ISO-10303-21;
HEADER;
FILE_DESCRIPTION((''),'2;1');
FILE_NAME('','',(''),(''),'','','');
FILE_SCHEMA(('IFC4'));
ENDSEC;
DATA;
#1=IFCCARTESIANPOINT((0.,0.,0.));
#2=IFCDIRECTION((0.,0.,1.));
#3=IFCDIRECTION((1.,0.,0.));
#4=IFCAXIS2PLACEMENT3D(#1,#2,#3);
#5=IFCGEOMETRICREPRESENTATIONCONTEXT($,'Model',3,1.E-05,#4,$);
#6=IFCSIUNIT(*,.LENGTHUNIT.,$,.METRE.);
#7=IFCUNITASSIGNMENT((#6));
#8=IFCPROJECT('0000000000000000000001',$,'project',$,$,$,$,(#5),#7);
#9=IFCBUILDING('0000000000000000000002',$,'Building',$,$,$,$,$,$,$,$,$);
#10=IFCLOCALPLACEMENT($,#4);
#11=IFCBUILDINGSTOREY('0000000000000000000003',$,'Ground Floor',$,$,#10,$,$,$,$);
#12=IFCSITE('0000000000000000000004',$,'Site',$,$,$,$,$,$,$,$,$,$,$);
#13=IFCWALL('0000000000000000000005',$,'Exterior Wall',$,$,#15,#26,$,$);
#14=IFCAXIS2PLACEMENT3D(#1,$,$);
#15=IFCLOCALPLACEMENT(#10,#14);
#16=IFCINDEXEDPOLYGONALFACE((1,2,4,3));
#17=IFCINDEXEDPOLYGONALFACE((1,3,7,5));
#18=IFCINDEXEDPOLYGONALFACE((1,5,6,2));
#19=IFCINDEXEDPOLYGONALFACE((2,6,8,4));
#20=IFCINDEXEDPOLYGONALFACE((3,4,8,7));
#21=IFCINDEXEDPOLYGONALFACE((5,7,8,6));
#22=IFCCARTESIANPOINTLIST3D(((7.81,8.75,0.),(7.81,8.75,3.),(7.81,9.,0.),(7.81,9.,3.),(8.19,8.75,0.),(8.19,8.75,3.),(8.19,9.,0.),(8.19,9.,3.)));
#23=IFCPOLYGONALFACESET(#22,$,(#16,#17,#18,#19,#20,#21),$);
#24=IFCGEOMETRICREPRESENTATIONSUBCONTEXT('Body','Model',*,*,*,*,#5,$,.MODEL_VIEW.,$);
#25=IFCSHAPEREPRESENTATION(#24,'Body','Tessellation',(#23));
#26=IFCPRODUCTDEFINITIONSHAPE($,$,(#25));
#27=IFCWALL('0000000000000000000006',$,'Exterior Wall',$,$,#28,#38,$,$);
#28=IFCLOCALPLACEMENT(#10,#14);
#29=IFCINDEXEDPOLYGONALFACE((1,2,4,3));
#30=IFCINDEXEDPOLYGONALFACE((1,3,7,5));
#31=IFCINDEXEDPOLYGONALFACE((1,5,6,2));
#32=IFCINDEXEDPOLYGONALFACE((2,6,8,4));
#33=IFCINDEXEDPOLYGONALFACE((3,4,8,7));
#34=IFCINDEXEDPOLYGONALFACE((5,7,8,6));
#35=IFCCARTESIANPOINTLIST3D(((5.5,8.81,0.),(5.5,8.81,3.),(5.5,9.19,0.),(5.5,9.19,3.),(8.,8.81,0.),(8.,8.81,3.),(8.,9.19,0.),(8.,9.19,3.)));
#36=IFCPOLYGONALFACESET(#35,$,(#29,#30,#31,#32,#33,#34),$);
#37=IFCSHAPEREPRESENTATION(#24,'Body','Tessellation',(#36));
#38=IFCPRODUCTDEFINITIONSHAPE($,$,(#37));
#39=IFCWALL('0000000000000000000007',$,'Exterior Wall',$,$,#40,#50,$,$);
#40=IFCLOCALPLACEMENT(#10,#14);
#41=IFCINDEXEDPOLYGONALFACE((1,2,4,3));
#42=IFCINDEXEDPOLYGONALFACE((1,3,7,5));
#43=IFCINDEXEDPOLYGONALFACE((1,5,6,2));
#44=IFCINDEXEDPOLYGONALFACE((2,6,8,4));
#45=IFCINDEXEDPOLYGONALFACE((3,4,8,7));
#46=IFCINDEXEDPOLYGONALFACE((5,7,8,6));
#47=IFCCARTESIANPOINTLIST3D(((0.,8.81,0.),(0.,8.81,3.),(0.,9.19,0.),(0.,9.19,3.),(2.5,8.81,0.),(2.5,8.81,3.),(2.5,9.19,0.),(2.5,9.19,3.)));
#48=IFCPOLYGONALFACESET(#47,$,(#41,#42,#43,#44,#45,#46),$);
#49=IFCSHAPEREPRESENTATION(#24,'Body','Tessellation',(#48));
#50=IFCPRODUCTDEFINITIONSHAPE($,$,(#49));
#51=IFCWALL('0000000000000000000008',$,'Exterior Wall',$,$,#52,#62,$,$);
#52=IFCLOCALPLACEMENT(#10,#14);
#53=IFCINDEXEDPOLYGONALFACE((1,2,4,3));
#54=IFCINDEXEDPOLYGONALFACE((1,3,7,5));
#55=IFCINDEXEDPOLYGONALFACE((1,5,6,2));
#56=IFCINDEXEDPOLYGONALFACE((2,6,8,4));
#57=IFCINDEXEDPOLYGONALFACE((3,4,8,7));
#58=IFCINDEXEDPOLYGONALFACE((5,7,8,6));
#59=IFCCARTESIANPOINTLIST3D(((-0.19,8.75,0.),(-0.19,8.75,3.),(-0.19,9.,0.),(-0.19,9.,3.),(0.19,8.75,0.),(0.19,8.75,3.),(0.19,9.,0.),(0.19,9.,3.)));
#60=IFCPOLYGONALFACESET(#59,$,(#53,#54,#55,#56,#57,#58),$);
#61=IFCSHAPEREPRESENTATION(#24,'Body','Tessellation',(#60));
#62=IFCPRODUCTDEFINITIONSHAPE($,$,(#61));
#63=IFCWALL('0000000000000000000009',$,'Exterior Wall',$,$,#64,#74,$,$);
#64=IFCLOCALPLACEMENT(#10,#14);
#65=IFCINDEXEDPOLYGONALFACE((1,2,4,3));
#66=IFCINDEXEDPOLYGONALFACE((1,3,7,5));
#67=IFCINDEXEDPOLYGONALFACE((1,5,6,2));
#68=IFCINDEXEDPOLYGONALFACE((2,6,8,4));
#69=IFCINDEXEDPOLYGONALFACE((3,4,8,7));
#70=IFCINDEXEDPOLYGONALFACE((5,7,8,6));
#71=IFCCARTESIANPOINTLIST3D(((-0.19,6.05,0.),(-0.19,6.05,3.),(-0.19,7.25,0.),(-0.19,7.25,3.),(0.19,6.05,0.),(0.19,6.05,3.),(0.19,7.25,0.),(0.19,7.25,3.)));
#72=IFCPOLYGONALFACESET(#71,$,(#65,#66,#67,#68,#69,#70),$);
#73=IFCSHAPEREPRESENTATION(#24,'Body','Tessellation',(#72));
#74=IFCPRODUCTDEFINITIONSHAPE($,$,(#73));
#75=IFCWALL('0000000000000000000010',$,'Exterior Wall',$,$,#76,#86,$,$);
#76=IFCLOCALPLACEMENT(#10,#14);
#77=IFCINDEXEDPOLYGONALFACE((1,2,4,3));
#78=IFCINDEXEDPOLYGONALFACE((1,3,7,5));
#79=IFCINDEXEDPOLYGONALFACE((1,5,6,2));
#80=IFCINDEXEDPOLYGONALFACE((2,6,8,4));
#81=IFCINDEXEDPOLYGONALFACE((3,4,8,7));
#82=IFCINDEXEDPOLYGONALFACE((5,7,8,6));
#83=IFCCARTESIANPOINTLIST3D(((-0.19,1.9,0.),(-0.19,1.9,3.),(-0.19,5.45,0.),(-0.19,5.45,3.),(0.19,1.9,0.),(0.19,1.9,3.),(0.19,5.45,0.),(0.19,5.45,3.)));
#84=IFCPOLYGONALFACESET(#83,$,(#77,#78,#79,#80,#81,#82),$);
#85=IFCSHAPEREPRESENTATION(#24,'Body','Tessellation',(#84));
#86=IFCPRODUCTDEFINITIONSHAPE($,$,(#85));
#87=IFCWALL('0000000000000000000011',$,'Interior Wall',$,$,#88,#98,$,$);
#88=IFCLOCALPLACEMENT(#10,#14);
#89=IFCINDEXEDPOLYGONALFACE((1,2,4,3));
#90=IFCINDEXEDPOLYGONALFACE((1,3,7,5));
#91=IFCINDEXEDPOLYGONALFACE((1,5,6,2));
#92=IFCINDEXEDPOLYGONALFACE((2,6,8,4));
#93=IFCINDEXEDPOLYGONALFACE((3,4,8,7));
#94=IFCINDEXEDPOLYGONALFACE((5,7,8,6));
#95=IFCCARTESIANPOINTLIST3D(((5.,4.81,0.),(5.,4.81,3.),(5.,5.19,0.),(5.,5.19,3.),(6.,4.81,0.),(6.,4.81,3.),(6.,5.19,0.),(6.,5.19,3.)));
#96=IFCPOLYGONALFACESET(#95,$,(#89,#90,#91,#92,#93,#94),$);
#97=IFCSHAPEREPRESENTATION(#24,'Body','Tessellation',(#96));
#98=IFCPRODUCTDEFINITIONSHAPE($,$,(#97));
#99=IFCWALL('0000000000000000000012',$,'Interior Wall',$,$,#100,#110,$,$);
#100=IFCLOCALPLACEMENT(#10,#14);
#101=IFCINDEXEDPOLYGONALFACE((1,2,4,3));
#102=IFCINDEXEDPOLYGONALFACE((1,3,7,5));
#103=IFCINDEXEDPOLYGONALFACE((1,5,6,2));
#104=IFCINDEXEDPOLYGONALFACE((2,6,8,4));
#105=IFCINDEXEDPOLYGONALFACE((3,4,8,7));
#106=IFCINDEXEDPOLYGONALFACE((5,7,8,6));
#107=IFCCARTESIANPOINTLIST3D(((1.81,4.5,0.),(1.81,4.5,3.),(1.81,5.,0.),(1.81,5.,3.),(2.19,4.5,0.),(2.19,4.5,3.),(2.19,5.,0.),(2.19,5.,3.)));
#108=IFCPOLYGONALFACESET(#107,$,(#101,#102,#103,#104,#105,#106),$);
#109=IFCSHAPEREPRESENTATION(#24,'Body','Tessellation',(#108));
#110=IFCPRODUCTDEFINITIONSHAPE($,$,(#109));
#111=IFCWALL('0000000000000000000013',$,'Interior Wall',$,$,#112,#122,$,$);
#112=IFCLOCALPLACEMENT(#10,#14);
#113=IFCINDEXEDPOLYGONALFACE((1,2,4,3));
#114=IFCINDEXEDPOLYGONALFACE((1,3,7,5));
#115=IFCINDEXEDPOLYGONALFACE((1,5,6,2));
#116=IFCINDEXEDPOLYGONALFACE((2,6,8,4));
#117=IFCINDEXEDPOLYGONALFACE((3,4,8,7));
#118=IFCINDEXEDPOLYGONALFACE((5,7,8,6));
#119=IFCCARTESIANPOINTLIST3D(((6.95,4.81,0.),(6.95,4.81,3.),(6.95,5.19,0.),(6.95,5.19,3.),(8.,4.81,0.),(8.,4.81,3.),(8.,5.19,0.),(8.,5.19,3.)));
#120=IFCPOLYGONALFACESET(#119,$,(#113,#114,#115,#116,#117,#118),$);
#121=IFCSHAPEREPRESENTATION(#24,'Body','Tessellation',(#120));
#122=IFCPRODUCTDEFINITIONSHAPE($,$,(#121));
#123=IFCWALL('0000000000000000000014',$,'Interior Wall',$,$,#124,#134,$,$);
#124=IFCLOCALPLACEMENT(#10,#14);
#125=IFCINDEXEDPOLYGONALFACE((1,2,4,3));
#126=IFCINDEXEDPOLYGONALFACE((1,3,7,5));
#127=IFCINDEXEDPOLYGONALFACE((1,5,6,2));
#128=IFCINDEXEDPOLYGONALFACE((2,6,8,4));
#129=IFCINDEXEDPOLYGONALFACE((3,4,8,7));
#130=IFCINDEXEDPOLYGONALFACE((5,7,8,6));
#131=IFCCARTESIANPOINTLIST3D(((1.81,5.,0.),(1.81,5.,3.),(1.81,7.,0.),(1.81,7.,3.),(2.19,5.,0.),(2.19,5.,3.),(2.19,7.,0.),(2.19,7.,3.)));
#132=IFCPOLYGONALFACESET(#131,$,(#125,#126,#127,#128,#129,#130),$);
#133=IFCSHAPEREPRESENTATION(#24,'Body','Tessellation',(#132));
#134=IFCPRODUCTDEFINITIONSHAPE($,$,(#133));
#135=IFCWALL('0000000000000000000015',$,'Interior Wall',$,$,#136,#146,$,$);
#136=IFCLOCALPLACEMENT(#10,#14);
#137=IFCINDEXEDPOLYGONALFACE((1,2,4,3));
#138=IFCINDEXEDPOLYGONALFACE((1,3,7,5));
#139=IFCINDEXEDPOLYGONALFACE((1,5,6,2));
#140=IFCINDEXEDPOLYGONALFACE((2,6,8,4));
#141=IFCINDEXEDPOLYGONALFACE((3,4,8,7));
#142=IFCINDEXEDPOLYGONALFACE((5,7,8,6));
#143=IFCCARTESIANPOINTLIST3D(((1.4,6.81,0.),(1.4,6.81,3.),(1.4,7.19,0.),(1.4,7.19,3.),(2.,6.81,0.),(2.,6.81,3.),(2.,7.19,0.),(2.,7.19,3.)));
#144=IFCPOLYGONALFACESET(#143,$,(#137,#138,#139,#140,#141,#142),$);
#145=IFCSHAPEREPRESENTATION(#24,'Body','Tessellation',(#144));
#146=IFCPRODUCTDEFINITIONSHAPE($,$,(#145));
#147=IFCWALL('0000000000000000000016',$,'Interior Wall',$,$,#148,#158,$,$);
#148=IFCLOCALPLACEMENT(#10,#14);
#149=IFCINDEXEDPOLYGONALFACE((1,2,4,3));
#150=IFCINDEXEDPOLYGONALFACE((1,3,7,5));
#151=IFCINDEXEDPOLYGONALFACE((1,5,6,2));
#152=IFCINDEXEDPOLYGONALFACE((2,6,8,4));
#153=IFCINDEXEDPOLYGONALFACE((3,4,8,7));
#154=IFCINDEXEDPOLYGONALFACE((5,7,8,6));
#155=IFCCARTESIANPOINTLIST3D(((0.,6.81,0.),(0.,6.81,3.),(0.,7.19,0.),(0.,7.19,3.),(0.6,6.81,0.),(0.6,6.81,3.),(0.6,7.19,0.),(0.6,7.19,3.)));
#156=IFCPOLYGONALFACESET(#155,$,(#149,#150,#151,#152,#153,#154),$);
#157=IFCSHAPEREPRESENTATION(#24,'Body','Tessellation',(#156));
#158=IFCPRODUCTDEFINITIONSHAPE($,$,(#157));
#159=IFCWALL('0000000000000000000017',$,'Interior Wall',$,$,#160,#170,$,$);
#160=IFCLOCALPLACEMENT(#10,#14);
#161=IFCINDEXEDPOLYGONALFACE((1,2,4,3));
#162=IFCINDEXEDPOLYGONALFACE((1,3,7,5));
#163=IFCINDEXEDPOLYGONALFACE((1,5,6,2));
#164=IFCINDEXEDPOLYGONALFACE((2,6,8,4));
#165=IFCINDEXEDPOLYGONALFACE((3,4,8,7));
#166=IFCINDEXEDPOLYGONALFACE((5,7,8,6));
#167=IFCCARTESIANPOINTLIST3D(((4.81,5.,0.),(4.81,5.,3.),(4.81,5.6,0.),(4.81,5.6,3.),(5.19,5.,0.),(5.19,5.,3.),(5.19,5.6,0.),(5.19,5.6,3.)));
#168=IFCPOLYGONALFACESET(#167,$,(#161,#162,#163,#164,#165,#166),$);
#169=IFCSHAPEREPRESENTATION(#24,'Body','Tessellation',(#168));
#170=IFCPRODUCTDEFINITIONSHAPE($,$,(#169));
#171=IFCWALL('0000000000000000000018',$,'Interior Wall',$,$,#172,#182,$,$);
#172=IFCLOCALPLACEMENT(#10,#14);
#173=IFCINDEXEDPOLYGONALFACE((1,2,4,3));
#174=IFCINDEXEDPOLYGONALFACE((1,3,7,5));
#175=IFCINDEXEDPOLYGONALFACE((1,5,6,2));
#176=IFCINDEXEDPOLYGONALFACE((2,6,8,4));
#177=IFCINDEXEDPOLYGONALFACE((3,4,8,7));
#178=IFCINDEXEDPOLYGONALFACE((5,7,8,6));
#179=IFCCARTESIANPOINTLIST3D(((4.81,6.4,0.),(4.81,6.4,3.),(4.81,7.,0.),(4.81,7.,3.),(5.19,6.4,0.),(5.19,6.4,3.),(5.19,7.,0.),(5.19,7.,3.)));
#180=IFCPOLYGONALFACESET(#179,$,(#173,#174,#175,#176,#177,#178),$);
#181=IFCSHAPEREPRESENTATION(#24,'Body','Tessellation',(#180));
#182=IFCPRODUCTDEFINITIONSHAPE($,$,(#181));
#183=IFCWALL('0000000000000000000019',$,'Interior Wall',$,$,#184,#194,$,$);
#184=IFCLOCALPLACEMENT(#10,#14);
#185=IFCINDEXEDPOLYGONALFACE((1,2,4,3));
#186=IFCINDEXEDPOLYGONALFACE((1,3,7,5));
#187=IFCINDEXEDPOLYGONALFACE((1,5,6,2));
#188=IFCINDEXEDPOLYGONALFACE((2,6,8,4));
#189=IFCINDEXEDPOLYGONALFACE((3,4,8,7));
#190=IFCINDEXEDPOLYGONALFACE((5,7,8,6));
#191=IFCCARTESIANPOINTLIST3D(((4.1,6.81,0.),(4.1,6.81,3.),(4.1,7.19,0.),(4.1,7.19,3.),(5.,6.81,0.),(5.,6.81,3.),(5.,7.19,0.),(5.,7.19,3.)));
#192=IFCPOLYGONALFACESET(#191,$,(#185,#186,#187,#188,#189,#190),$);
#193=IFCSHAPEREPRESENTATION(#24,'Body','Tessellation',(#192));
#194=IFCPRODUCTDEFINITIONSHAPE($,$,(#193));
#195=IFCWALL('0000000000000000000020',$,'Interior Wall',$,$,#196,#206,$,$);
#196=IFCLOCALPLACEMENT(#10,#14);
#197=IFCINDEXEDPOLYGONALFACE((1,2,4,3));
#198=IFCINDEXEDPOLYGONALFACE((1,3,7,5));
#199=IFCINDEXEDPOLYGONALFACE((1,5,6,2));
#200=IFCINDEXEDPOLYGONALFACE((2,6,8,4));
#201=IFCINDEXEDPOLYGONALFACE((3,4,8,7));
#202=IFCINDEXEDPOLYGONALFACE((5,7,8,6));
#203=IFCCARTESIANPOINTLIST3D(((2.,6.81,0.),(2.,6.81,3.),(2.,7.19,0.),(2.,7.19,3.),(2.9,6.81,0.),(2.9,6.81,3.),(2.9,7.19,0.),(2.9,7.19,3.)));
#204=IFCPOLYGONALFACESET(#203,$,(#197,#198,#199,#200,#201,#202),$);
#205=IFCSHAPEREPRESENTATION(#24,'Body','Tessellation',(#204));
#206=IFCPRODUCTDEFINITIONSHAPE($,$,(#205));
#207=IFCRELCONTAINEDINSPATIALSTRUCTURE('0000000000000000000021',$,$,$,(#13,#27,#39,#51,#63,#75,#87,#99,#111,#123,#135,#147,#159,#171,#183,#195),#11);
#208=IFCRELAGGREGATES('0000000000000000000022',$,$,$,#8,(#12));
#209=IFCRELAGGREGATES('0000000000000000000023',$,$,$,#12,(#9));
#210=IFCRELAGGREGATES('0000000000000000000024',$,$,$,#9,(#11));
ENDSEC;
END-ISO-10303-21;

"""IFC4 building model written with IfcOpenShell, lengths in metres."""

from ifc_helpers import new_model, si_unit, frame, origin_with_axes, place, context, subcontext, project, spatial, indexed_curve, outline, extrude, element, save


model = new_model("IFC4")

# Units and contexts
model_context = context("Model", 3, precision=1e-05, world=origin_with_axes())
body_context = subcontext(model_context, "Body", "Model", "MODEL_VIEW")
ifc_project = project(units=[si_unit("LENGTHUNIT", "METRE")], contexts=[model_context])

# Site, building, storey
site = spatial("IfcSite", under=ifc_project, Name="Site")
building = spatial("IfcBuilding", under=site, Name="Building")
storey_placement = place(None, origin_with_axes())
storey = spatial("IfcBuildingStorey", under=building, at=storey_placement, Name="Ground Floor")

# Walls
wall_1_placement = place(storey_placement, frame((8.0, 8.75, 0.0), z_axis=(0.0, 0.0, 1.0), x_axis=(0.0, 1.0, 0.0)))
element("IfcWall", 1, at=wall_1_placement, inside=storey, Name="Exterior Wall", context=body_context, shape_type="SweptSolid", body=[
    extrude(outline(indexed_curve([(0.0, 0.0), (0.0, 0.38), (0.25, 0.38), (0.25, 0.0), (0.0, 0.0)], self_intersect=False)), frame((0.0, -0.19, 0.0), z_axis=(0.0, 0.0, 1.0), x_axis=(1.0, 0.0, 0.0)), (0.0, 0.0, 1.0), 3.0),
])
for number, where, z_axis, x_axis, name in (
    (2, (8.0, 9.0, 0.0), (0.0, 0.0, 1.0), (-1.0, 0.0, 0.0), "Exterior Wall"),
    (3, (2.5, 9.0, 0.0), (0.0, 0.0, 1.0), (-1.0, 0.0, 0.0), "Exterior Wall"),
):
    element("IfcWall", number, at=place(storey_placement, frame(where, z_axis=z_axis, x_axis=x_axis)), inside=storey, Name=name, context=body_context, shape_type="SweptSolid", body=[
        extrude(outline(indexed_curve([(0.0, 0.0), (0.0, 0.38), (2.5, 0.38), (2.5, 0.0), (0.0, 0.0)], self_intersect=False)), frame((0.0, -0.19, 0.0), z_axis=(0.0, 0.0, 1.0), x_axis=(1.0, 0.0, 0.0)), (0.0, 0.0, 1.0), 3.0),
    ])
wall_2_placement = place(storey_placement, frame((0.0, 9.0, 0.0), z_axis=(0.0, 0.0, 1.0), x_axis=(0.0, -1.0, 0.0)))
element("IfcWall", 4, at=wall_2_placement, inside=storey, Name="Exterior Wall", context=body_context, shape_type="SweptSolid", body=[
    extrude(outline(indexed_curve([(0.0, 0.0), (0.0, 0.38), (0.25, 0.38), (0.25, 0.0), (0.0, 0.0)], self_intersect=False)), frame((0.0, -0.19, 0.0), z_axis=(0.0, 0.0, 1.0), x_axis=(1.0, 0.0, 0.0)), (0.0, 0.0, 1.0), 3.0),
])
wall_3_placement = place(storey_placement, frame((0.0, 7.25, 0.0), z_axis=(0.0, 0.0, 1.0), x_axis=(0.0, -1.0, 0.0)))
element("IfcWall", 5, at=wall_3_placement, inside=storey, Name="Exterior Wall", context=body_context, shape_type="SweptSolid", body=[
    extrude(outline(indexed_curve([(0.0, 0.0), (0.0, 0.38), (1.2, 0.38), (1.2, 0.0), (0.0, 0.0)], self_intersect=False)), frame((0.0, -0.19, 0.0), z_axis=(0.0, 0.0, 1.0), x_axis=(1.0, 0.0, 0.0)), (0.0, 0.0, 1.0), 3.0),
])
wall_4_placement = place(storey_placement, frame((0.0, 5.45, 0.0), z_axis=(0.0, 0.0, 1.0), x_axis=(0.0, -1.0, 0.0)))
element("IfcWall", 6, at=wall_4_placement, inside=storey, Name="Exterior Wall", context=body_context, shape_type="SweptSolid", body=[
    extrude(outline(indexed_curve([(0.0, 0.0), (0.0, 0.38), (3.55, 0.38), (3.55, 0.0), (0.0, 0.0)], self_intersect=False)), frame((0.0, -0.19, 0.0), z_axis=(0.0, 0.0, 1.0), x_axis=(1.0, 0.0, 0.0)), (0.0, 0.0, 1.0), 3.0),
])
wall_5_placement = place(storey_placement, frame((6.0, 5.0, 0.0), z_axis=(0.0, 0.0, 1.0), x_axis=(-1.0, 0.0, 0.0)))
element("IfcWall", 7, at=wall_5_placement, inside=storey, Name="Interior Wall", context=body_context, shape_type="SweptSolid", body=[
    extrude(outline(indexed_curve([(0.0, 0.0), (0.0, 0.38), (1.0, 0.38), (1.0, 0.0), (0.0, 0.0)], self_intersect=False)), frame((0.0, -0.19, 0.0), z_axis=(0.0, 0.0, 1.0), x_axis=(1.0, 0.0, 0.0)), (0.0, 0.0, 1.0), 3.0),
])
wall_6_placement = place(storey_placement, frame((2.0, 5.0, 0.0), z_axis=(0.0, 0.0, 1.0), x_axis=(0.0, -1.0, 0.0)))
element("IfcWall", 8, at=wall_6_placement, inside=storey, Name="Interior Wall", context=body_context, shape_type="SweptSolid", body=[
    extrude(outline(indexed_curve([(0.0, 0.0), (0.0, 0.38), (0.5, 0.38), (0.5, 0.0), (0.0, 0.0)], self_intersect=False)), frame((0.0, -0.19, 0.0), z_axis=(0.0, 0.0, 1.0), x_axis=(1.0, 0.0, 0.0)), (0.0, 0.0, 1.0), 3.0),
])
wall_7_placement = place(storey_placement, frame((8.0, 5.0, 0.0), z_axis=(0.0, 0.0, 1.0), x_axis=(-1.0, 0.0, 0.0)))
element("IfcWall", 9, at=wall_7_placement, inside=storey, Name="Interior Wall", context=body_context, shape_type="SweptSolid", body=[
    extrude(outline(indexed_curve([(0.0, 0.0), (0.0, 0.38), (1.05, 0.38), (1.05, 0.0), (0.0, 0.0)], self_intersect=False)), frame((0.0, -0.19, 0.0), z_axis=(0.0, 0.0, 1.0), x_axis=(1.0, 0.0, 0.0)), (0.0, 0.0, 1.0), 3.0),
])
wall_8_placement = place(storey_placement, frame((2.0, 5.0, 0.0), z_axis=(0.0, 0.0, 1.0), x_axis=(0.0, 1.0, 0.0)))
element("IfcWall", 10, at=wall_8_placement, inside=storey, Name="Interior Wall", context=body_context, shape_type="SweptSolid", body=[
    extrude(outline(indexed_curve([(0.0, 0.0), (0.0, 0.38), (2.0, 0.38), (2.0, 0.0), (0.0, 0.0)], self_intersect=False)), frame((0.0, -0.19, 0.0), z_axis=(0.0, 0.0, 1.0), x_axis=(1.0, 0.0, 0.0)), (0.0, 0.0, 1.0), 3.0),
])
for number, where, z_axis, x_axis, name in (
    (11, (2.0, 7.0, 0.0), (0.0, 0.0, 1.0), (-1.0, 0.0, 0.0), "Interior Wall"),
    (12, (0.6, 7.0, 0.0), (0.0, 0.0, 1.0), (-1.0, 0.0, 0.0), "Interior Wall"),
):
    element("IfcWall", number, at=place(storey_placement, frame(where, z_axis=z_axis, x_axis=x_axis)), inside=storey, Name=name, context=body_context, shape_type="SweptSolid", body=[
        extrude(outline(indexed_curve([(0.0, 0.0), (0.0, 0.38), (0.6, 0.38), (0.6, 0.0), (0.0, 0.0)], self_intersect=False)), frame((0.0, -0.19, 0.0), z_axis=(0.0, 0.0, 1.0), x_axis=(1.0, 0.0, 0.0)), (0.0, 0.0, 1.0), 3.0),
    ])
for number, where, z_axis, x_axis, name in (
    (13, (5.0, 5.0, 0.0), (0.0, 0.0, 1.0), (0.0, 1.0, 0.0), "Interior Wall"),
    (14, (5.0, 6.4, 0.0), (0.0, 0.0, 1.0), (0.0, 1.0, 0.0), "Interior Wall"),
):
    element("IfcWall", number, at=place(storey_placement, frame(where, z_axis=z_axis, x_axis=x_axis)), inside=storey, Name=name, context=body_context, shape_type="SweptSolid", body=[
        extrude(outline(indexed_curve([(0.0, 0.0), (0.0, 0.38), (0.6, 0.38), (0.6, 0.0), (0.0, 0.0)], self_intersect=False)), frame((0.0, -0.19, 0.0), z_axis=(0.0, 0.0, 1.0), x_axis=(1.0, 0.0, 0.0)), (0.0, 0.0, 1.0), 3.0),
    ])
wall_9_placement = place(storey_placement, frame((5.0, 7.0, 0.0), z_axis=(0.0, 0.0, 1.0), x_axis=(-1.0, 0.0, 0.0)))
element("IfcWall", 15, at=wall_9_placement, inside=storey, Name="Interior Wall", context=body_context, shape_type="SweptSolid", body=[
    extrude(outline(indexed_curve([(0.0, 0.0), (0.0, 0.38), (0.9, 0.38), (0.9, 0.0), (0.0, 0.0)], self_intersect=False)), frame((0.0, -0.19, 0.0), z_axis=(0.0, 0.0, 1.0), x_axis=(1.0, 0.0, 0.0)), (0.0, 0.0, 1.0), 3.0),
])
wall_10_placement = place(storey_placement, frame((2.9, 7.0, 0.0), z_axis=(0.0, 0.0, 1.0), x_axis=(-1.0, 0.0, 0.0)))
element("IfcWall", 16, at=wall_10_placement, inside=storey, Name="Interior Wall", context=body_context, shape_type="SweptSolid", body=[
    extrude(outline(indexed_curve([(0.0, 0.0), (0.0, 0.38), (0.9, 0.38), (0.9, 0.0), (0.0, 0.0)], self_intersect=False)), frame((0.0, -0.19, 0.0), z_axis=(0.0, 0.0, 1.0), x_axis=(1.0, 0.0, 0.0)), (0.0, 0.0, 1.0), 3.0),
])

save(model, "model.ifc")
